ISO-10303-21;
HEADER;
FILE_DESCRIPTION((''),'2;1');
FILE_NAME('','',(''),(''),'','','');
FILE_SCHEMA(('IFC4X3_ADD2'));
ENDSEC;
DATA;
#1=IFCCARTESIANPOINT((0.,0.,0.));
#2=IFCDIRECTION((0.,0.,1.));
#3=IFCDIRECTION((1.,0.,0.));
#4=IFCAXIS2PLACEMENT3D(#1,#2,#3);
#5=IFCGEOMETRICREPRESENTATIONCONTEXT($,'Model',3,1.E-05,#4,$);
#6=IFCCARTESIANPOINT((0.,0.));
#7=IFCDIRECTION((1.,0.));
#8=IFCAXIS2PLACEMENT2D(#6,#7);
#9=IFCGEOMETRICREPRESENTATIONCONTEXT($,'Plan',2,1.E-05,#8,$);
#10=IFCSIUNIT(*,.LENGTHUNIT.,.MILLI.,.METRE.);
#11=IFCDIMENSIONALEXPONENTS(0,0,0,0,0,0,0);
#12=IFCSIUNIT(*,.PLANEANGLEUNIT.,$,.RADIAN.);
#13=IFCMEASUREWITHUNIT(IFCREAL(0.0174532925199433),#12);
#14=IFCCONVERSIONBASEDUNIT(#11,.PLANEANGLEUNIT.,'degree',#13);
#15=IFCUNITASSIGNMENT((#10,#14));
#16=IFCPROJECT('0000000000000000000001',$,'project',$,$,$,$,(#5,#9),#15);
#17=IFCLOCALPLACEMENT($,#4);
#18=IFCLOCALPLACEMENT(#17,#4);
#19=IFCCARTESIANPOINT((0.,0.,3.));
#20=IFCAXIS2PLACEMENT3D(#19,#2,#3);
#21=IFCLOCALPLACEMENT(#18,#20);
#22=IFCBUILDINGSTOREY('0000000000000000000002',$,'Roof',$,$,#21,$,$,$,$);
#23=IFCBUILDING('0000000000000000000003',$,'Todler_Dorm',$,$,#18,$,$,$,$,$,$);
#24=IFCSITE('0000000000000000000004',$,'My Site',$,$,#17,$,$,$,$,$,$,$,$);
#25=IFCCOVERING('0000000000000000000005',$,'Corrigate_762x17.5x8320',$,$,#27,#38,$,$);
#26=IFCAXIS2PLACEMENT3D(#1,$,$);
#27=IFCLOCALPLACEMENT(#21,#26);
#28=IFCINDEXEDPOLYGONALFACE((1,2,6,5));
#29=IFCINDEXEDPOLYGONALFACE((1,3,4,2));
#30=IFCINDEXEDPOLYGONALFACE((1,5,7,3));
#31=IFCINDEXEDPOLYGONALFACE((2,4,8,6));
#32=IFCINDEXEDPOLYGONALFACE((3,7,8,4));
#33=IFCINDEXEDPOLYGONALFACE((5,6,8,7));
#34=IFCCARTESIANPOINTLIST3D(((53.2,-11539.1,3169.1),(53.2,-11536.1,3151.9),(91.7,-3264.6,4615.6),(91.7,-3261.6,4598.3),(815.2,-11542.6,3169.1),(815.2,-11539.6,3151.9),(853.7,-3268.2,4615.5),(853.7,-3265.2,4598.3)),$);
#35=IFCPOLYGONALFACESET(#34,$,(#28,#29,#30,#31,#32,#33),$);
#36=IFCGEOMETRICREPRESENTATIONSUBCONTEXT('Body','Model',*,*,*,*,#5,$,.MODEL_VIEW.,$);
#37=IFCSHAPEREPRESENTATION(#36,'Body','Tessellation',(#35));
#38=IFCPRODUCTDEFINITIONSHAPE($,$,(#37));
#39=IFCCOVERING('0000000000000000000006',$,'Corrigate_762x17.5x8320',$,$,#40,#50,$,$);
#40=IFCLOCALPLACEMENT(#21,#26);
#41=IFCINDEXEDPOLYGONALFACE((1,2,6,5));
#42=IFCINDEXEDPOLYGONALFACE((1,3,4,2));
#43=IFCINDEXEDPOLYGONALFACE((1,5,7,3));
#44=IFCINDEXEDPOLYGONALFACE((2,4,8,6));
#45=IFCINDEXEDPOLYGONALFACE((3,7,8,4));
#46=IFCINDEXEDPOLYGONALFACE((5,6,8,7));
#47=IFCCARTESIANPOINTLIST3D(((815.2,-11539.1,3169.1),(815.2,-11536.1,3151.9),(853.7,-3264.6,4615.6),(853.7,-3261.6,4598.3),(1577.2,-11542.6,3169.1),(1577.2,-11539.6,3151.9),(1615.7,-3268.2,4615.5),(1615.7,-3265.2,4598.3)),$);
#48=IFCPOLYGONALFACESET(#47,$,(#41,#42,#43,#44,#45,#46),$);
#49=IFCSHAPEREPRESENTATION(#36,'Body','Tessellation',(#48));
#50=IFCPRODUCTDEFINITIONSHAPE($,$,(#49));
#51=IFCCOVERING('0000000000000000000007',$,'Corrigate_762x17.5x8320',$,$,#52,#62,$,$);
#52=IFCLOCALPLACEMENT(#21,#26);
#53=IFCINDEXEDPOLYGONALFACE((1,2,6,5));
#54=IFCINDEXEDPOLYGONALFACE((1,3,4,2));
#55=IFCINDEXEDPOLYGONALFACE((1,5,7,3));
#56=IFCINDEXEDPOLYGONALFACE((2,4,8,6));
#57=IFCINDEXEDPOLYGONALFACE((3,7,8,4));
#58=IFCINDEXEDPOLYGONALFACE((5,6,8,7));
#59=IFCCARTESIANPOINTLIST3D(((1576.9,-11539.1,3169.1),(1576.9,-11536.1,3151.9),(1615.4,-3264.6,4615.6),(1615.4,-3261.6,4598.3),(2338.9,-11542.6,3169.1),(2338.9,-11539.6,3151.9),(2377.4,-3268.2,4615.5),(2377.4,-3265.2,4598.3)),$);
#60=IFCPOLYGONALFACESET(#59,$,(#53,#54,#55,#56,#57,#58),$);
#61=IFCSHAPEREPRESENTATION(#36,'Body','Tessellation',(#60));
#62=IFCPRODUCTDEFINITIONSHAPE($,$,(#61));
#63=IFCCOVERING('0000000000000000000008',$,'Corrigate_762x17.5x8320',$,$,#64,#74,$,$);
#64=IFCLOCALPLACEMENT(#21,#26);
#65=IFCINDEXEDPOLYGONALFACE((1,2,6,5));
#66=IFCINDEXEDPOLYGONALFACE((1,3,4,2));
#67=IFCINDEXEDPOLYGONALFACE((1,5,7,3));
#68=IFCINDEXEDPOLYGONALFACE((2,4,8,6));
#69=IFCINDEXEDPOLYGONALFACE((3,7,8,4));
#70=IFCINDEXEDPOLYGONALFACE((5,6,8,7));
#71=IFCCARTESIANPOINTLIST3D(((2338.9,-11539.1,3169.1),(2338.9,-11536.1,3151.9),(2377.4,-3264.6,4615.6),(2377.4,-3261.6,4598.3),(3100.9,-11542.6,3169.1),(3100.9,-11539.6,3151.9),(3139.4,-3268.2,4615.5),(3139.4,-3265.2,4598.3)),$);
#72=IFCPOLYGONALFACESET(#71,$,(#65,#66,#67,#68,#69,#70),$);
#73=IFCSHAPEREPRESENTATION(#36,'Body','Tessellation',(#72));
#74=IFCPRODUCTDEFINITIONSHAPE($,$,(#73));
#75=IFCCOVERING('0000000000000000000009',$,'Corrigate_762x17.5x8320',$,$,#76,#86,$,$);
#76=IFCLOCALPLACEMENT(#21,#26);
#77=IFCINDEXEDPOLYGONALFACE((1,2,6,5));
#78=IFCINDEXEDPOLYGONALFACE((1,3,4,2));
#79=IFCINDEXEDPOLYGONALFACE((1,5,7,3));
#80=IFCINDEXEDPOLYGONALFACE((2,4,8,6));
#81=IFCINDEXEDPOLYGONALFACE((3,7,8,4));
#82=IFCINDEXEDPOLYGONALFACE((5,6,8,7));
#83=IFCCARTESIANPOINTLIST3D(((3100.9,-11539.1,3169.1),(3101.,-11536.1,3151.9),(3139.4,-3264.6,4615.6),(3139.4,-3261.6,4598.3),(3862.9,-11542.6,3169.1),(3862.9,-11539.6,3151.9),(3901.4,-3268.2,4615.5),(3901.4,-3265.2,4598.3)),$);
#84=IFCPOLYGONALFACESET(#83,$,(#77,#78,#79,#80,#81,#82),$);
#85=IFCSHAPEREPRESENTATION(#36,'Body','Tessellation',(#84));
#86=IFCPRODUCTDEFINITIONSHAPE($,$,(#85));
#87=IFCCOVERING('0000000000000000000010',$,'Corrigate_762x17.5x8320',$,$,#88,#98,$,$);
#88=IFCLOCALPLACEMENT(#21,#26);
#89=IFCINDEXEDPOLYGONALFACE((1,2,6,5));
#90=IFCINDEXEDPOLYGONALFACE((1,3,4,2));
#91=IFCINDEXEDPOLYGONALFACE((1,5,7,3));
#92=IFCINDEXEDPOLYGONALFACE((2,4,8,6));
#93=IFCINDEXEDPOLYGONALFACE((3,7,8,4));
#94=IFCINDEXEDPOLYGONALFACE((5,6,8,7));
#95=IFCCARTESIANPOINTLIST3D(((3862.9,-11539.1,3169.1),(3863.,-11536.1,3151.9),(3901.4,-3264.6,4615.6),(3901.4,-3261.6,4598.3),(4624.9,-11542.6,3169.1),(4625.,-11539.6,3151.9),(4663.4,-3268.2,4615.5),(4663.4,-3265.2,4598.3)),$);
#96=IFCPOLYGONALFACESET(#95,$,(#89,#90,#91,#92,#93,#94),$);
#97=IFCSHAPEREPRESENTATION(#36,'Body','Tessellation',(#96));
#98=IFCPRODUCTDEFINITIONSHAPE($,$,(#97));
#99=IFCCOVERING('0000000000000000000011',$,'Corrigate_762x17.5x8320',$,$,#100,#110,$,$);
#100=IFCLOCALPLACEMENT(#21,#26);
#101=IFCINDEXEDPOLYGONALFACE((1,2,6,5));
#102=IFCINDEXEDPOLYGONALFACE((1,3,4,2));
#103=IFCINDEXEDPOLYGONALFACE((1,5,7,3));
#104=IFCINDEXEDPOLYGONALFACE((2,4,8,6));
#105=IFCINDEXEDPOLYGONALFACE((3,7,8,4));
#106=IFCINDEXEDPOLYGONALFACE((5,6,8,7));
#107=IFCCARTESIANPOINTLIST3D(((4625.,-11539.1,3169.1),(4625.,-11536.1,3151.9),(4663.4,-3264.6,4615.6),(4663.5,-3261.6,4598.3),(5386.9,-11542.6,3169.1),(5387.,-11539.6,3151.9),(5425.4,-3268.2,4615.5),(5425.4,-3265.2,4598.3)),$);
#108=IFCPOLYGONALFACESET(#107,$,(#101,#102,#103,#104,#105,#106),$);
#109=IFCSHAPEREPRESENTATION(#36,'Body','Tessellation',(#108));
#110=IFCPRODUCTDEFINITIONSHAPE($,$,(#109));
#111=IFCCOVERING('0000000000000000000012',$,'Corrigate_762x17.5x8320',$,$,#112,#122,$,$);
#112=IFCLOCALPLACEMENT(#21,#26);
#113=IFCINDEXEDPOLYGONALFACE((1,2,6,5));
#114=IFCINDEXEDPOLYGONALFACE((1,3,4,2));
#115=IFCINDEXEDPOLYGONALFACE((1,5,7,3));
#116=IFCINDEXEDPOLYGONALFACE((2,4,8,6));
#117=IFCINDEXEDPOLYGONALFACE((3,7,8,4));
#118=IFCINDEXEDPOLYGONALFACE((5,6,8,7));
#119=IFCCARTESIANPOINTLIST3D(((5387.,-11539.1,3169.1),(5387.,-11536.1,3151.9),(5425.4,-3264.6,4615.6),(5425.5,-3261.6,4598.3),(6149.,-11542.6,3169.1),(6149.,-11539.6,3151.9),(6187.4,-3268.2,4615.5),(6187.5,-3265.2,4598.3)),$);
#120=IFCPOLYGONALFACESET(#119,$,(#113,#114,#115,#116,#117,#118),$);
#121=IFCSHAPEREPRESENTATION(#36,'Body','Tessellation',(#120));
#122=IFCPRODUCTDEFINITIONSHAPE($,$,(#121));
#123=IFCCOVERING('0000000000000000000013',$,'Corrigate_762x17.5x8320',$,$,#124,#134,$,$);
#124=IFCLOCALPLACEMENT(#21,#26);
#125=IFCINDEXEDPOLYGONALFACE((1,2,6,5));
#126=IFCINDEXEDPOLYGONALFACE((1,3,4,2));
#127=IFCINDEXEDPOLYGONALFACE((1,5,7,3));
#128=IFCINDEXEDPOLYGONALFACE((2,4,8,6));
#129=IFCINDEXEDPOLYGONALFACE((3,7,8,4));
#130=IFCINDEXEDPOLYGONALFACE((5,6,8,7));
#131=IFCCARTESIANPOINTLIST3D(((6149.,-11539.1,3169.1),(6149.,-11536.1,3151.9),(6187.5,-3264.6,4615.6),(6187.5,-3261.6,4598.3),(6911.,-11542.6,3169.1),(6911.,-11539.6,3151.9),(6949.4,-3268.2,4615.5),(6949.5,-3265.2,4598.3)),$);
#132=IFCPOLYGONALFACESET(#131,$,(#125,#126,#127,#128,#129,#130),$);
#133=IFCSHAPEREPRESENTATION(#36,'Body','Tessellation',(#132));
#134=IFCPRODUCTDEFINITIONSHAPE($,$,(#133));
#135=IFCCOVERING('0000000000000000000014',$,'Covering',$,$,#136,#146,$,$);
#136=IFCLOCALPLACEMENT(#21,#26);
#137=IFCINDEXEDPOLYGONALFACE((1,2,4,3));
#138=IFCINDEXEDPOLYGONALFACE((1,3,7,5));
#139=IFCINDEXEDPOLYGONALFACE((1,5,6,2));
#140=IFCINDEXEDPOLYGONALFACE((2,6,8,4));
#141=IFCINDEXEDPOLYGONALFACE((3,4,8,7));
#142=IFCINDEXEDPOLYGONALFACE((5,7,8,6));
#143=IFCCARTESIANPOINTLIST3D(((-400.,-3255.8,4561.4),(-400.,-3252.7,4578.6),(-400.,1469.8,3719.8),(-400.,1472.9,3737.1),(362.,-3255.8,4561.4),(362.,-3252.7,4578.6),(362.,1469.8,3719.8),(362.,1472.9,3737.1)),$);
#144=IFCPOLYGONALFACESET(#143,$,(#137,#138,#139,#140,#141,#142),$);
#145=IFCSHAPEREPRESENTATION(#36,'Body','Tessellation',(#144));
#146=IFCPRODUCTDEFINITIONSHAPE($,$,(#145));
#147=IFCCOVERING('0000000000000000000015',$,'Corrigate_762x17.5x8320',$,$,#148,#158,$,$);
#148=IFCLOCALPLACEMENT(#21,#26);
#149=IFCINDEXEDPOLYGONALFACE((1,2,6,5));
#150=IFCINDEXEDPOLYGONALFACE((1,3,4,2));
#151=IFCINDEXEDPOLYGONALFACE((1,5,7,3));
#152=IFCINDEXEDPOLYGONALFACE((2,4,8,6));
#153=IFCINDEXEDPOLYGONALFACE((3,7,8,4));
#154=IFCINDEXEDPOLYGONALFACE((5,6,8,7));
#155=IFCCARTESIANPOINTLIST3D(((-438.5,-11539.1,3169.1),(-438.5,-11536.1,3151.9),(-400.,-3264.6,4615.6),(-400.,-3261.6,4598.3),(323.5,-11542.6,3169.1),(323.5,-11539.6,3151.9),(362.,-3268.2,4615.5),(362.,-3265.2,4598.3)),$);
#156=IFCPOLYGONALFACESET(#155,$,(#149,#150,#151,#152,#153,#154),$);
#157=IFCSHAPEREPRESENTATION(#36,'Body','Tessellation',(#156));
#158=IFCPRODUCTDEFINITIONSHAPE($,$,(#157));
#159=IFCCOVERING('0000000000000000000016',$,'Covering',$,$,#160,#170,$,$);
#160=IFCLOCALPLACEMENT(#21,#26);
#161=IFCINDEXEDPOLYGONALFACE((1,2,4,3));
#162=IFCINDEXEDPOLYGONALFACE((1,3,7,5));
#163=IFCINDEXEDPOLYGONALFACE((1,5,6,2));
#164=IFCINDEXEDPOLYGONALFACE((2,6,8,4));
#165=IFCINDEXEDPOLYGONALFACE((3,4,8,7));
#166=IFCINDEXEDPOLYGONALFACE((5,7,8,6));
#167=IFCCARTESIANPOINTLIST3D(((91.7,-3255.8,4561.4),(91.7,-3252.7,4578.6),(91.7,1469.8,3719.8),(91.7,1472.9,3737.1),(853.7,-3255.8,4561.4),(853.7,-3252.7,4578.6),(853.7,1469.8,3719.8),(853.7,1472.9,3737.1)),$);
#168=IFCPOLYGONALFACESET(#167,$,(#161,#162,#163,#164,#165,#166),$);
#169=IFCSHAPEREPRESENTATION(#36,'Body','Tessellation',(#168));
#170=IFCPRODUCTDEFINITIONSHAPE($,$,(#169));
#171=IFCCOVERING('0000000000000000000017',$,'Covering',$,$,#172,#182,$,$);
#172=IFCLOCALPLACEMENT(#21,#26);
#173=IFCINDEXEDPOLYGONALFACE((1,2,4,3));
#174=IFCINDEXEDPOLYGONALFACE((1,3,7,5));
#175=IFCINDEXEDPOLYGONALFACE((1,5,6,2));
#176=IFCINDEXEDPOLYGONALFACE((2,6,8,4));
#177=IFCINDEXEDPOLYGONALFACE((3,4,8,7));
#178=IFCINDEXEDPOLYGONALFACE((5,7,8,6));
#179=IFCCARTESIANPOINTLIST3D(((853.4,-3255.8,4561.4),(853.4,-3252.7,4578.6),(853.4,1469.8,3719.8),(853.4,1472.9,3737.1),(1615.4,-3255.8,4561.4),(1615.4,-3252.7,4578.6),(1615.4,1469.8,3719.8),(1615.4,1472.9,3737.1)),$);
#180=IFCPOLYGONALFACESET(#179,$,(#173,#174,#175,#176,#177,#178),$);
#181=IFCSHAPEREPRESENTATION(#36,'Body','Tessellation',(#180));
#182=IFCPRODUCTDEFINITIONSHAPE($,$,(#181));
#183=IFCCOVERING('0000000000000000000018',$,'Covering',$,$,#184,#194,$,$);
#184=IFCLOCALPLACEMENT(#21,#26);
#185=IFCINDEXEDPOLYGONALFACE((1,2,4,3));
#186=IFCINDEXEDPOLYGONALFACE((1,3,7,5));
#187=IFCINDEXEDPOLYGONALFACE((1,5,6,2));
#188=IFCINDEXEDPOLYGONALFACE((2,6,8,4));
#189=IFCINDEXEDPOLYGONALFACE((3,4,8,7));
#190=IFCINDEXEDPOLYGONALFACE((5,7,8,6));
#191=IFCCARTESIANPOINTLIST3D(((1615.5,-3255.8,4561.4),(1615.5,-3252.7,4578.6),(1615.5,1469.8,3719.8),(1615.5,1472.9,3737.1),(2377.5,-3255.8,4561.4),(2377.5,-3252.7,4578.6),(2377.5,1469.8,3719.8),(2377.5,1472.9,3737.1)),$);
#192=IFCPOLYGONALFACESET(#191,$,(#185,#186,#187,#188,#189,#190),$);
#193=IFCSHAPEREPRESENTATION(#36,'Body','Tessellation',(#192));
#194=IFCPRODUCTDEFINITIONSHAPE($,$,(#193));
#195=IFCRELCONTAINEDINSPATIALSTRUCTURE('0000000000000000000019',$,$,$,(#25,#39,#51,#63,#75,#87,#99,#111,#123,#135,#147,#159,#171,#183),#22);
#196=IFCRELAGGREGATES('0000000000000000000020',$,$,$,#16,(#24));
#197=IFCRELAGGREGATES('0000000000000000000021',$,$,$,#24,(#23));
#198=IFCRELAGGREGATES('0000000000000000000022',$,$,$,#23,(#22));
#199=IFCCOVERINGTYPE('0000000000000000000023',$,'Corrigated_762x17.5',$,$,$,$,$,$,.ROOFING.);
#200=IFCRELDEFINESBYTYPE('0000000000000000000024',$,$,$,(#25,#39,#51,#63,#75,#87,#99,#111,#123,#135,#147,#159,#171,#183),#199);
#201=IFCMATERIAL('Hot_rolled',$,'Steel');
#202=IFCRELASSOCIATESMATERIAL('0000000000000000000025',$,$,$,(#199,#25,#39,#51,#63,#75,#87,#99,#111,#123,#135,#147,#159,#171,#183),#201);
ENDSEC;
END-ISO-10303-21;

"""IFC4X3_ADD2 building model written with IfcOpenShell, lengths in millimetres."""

from ifc_helpers import new_model, entity, si_unit, converted_unit, frame, origin_with_axes, origin_2d_with_axis, place, context, subcontext, project, spatial, rectangle, extrude, material, material_profile, profile_set, profile_usage, type_object, element, save


model = new_model("IFC4X3_ADD2")

# Units and contexts
model_context = context("Model", 3, precision=1e-05, world=origin_with_axes())
plan_context = context("Plan", 2, precision=1e-05, world=origin_2d_with_axis())
body_context = subcontext(model_context, "Body", "Model", "MODEL_VIEW")
ifc_project = project(units=[si_unit("LENGTHUNIT", "METRE", prefix="MILLI"), converted_unit("PLANEANGLEUNIT", "degree", entity("IfcReal", 0.0174532925199433), si_unit("PLANEANGLEUNIT", "RADIAN"), dimensions=[0, 0, 0, 0, 0, 0, 0])], contexts=[model_context, plan_context])

# Site, building, storey
site_placement = place(None, origin_with_axes())
site = spatial("IfcSite", under=ifc_project, at=site_placement, Name="My Site")
building_placement = place(site_placement, origin_with_axes())
building = spatial("IfcBuilding", under=site, at=building_placement, Name="Todler_Dorm")
storey_placement = place(building_placement, frame((0.0, 0.0, 3.0), z_axis=(0.0, 0.0, 1.0), x_axis=(1.0, 0.0, 0.0)))
storey = spatial("IfcBuildingStorey", under=building, at=storey_placement, Name="Roof")

# Coverings
ifc_material_1 = material(Name="Hot_rolled", Category="Steel")
ifc_material_profile = material_profile(ifc_material_1, rectangle(XDim=762.0, YDim=17.5))
ifc_profile_set = profile_set([ifc_material_profile])
ifc_profile_usage_1 = profile_usage(ifc_profile_set, cardinal=5)
covering_type = type_object("IfcCoveringType", Name="Corrigated_762x17.5", PredefinedType="ROOFING", material=ifc_profile_set)
covering_1_placement = place(storey_placement, frame((472.7, -3264.9, 4606.9), z_axis=(-0.004582, -0.985052, -0.172196), x_axis=(0.999989, -0.00465, -0.000006)))
element("IfcCovering", 1, at=covering_1_placement, inside=storey, type_object=covering_type, material=ifc_profile_usage_1, Name="Corrigate_762x17.5x8320", context=body_context, shape_type="SweptSolid", body=[
    extrude(rectangle(XDim=762.0, YDim=17.5), origin_with_axes(), (0.0, 0.0, 1.0), 8400.0),
])
ifc_profile_usage_2 = profile_usage(ifc_profile_set, cardinal=5)
covering_2_placement = place(storey_placement, frame((1234.7, -3264.9, 4606.9), z_axis=(-0.004582, -0.985052, -0.172196), x_axis=(0.999989, -0.00465, -0.000006)))
element("IfcCovering", 2, at=covering_2_placement, inside=storey, type_object=covering_type, material=ifc_profile_usage_2, Name="Corrigate_762x17.5x8320", context=body_context, shape_type="SweptSolid", body=[
    extrude(rectangle(XDim=762.0, YDim=17.5), origin_with_axes(), (0.0, 0.0, 1.0), 8400.0),
])
ifc_profile_usage_3 = profile_usage(ifc_profile_set, cardinal=5)
covering_3_placement = place(storey_placement, frame((1996.4, -3264.9, 4606.9), z_axis=(-0.004582, -0.985052, -0.172196), x_axis=(0.999989, -0.00465, -0.000006)))
element("IfcCovering", 3, at=covering_3_placement, inside=storey, type_object=covering_type, material=ifc_profile_usage_3, Name="Corrigate_762x17.5x8320", context=body_context, shape_type="SweptSolid", body=[
    extrude(rectangle(XDim=762.0, YDim=17.5), origin_with_axes(), (0.0, 0.0, 1.0), 8400.0),
])
ifc_profile_usage_4 = profile_usage(ifc_profile_set, cardinal=5)
covering_4_placement = place(storey_placement, frame((2758.4, -3264.9, 4606.9), z_axis=(-0.004582, -0.985052, -0.172196), x_axis=(0.999989, -0.00465, -0.000006)))
element("IfcCovering", 4, at=covering_4_placement, inside=storey, type_object=covering_type, material=ifc_profile_usage_4, Name="Corrigate_762x17.5x8320", context=body_context, shape_type="SweptSolid", body=[
    extrude(rectangle(XDim=762.0, YDim=17.5), origin_with_axes(), (0.0, 0.0, 1.0), 8400.0),
])
ifc_profile_usage_5 = profile_usage(ifc_profile_set, cardinal=5)
covering_5_placement = place(storey_placement, frame((3520.4, -3264.9, 4606.9), z_axis=(-0.004582, -0.985052, -0.172196), x_axis=(0.999989, -0.00465, -0.000006)))
element("IfcCovering", 5, at=covering_5_placement, inside=storey, type_object=covering_type, material=ifc_profile_usage_5, Name="Corrigate_762x17.5x8320", context=body_context, shape_type="SweptSolid", body=[
    extrude(rectangle(XDim=762.0, YDim=17.5), origin_with_axes(), (0.0, 0.0, 1.0), 8400.0),
])
ifc_profile_usage_6 = profile_usage(ifc_profile_set, cardinal=5)
covering_6_placement = place(storey_placement, frame((4282.4, -3264.9, 4606.9), z_axis=(-0.004582, -0.985052, -0.172196), x_axis=(0.999989, -0.00465, -0.000006)))
element("IfcCovering", 6, at=covering_6_placement, inside=storey, type_object=covering_type, material=ifc_profile_usage_6, Name="Corrigate_762x17.5x8320", context=body_context, shape_type="SweptSolid", body=[
    extrude(rectangle(XDim=762.0, YDim=17.5), origin_with_axes(), (0.0, 0.0, 1.0), 8400.0),
])
ifc_profile_usage_7 = profile_usage(ifc_profile_set, cardinal=5)
covering_7_placement = place(storey_placement, frame((5044.4, -3264.9, 4606.9), z_axis=(-0.004582, -0.985052, -0.172196), x_axis=(0.999989, -0.00465, -0.000006)))
element("IfcCovering", 7, at=covering_7_placement, inside=storey, type_object=covering_type, material=ifc_profile_usage_7, Name="Corrigate_762x17.5x8320", context=body_context, shape_type="SweptSolid", body=[
    extrude(rectangle(XDim=762.0, YDim=17.5), origin_with_axes(), (0.0, 0.0, 1.0), 8400.0),
])
ifc_profile_usage_8 = profile_usage(ifc_profile_set, cardinal=5)
covering_8_placement = place(storey_placement, frame((5806.5, -3264.9, 4606.9), z_axis=(-0.004582, -0.985052, -0.172196), x_axis=(0.999989, -0.00465, -0.000006)))
element("IfcCovering", 8, at=covering_8_placement, inside=storey, type_object=covering_type, material=ifc_profile_usage_8, Name="Corrigate_762x17.5x8320", context=body_context, shape_type="SweptSolid", body=[
    extrude(rectangle(XDim=762.0, YDim=17.5), origin_with_axes(), (0.0, 0.0, 1.0), 8400.0),
])
ifc_profile_usage_9 = profile_usage(ifc_profile_set, cardinal=5)
covering_9_placement = place(storey_placement, frame((6568.5, -3264.9, 4606.9), z_axis=(-0.004582, -0.985052, -0.172196), x_axis=(0.999989, -0.00465, -0.000006)))
element("IfcCovering", 9, at=covering_9_placement, inside=storey, type_object=covering_type, material=ifc_profile_usage_9, Name="Corrigate_762x17.5x8320", context=body_context, shape_type="SweptSolid", body=[
    extrude(rectangle(XDim=762.0, YDim=17.5), origin_with_axes(), (0.0, 0.0, 1.0), 8400.0),
])
ifc_profile_usage_10 = profile_usage(ifc_profile_set, cardinal=5)
covering_10_placement = place(storey_placement, frame((-19.0, 1471.4, 3728.4), z_axis=(0.0, -0.98451, 0.175329), x_axis=(1.0, 0.0, 0.0)))
element("IfcCovering", 10, at=covering_10_placement, inside=storey, type_object=covering_type, material=ifc_profile_usage_10, Name="Covering", context=body_context, shape_type="SweptSolid", body=[
    extrude(rectangle(XDim=762.0, YDim=17.5), origin_with_axes(), (0.0, 0.0, 1.0), 4800.0),
])
ifc_profile_usage_11 = profile_usage(ifc_profile_set, cardinal=5)
covering_11_placement = place(storey_placement, frame((-19.0, -3264.9, 4606.9), z_axis=(-0.004582, -0.985052, -0.172196), x_axis=(0.999989, -0.00465, -0.000006)))
element("IfcCovering", 11, at=covering_11_placement, inside=storey, type_object=covering_type, material=ifc_profile_usage_11, Name="Corrigate_762x17.5x8320", context=body_context, shape_type="SweptSolid", body=[
    extrude(rectangle(XDim=762.0, YDim=17.5), origin_with_axes(), (0.0, 0.0, 1.0), 8400.0),
])
ifc_profile_usage_12 = profile_usage(ifc_profile_set, cardinal=5)
covering_12_placement = place(storey_placement, frame((472.7, 1471.4, 3728.4), z_axis=(0.0, -0.98451, 0.175329), x_axis=(1.0, 0.0, 0.0)))
element("IfcCovering", 12, at=covering_12_placement, inside=storey, type_object=covering_type, material=ifc_profile_usage_12, Name="Covering", context=body_context, shape_type="SweptSolid", body=[
    extrude(rectangle(XDim=762.0, YDim=17.5), origin_with_axes(), (0.0, 0.0, 1.0), 4800.0),
])
ifc_profile_usage_13 = profile_usage(ifc_profile_set, cardinal=5)
covering_13_placement = place(storey_placement, frame((1234.4, 1471.4, 3728.4), z_axis=(0.0, -0.98451, 0.175329), x_axis=(1.0, 0.0, 0.0)))
element("IfcCovering", 13, at=covering_13_placement, inside=storey, type_object=covering_type, material=ifc_profile_usage_13, Name="Covering", context=body_context, shape_type="SweptSolid", body=[
    extrude(rectangle(XDim=762.0, YDim=17.5), origin_with_axes(), (0.0, 0.0, 1.0), 4800.0),
])
ifc_profile_usage_14 = profile_usage(ifc_profile_set, cardinal=5)
covering_14_placement = place(storey_placement, frame((1996.5, 1471.4, 3728.4), z_axis=(0.0, -0.98451, 0.175329), x_axis=(1.0, 0.0, 0.0)))
element("IfcCovering", 14, at=covering_14_placement, inside=storey, type_object=covering_type, material=ifc_profile_usage_14, Name="Covering", context=body_context, shape_type="SweptSolid", body=[
    extrude(rectangle(XDim=762.0, YDim=17.5), origin_with_axes(), (0.0, 0.0, 1.0), 4800.0),
])

save(model, "model.ifc")
